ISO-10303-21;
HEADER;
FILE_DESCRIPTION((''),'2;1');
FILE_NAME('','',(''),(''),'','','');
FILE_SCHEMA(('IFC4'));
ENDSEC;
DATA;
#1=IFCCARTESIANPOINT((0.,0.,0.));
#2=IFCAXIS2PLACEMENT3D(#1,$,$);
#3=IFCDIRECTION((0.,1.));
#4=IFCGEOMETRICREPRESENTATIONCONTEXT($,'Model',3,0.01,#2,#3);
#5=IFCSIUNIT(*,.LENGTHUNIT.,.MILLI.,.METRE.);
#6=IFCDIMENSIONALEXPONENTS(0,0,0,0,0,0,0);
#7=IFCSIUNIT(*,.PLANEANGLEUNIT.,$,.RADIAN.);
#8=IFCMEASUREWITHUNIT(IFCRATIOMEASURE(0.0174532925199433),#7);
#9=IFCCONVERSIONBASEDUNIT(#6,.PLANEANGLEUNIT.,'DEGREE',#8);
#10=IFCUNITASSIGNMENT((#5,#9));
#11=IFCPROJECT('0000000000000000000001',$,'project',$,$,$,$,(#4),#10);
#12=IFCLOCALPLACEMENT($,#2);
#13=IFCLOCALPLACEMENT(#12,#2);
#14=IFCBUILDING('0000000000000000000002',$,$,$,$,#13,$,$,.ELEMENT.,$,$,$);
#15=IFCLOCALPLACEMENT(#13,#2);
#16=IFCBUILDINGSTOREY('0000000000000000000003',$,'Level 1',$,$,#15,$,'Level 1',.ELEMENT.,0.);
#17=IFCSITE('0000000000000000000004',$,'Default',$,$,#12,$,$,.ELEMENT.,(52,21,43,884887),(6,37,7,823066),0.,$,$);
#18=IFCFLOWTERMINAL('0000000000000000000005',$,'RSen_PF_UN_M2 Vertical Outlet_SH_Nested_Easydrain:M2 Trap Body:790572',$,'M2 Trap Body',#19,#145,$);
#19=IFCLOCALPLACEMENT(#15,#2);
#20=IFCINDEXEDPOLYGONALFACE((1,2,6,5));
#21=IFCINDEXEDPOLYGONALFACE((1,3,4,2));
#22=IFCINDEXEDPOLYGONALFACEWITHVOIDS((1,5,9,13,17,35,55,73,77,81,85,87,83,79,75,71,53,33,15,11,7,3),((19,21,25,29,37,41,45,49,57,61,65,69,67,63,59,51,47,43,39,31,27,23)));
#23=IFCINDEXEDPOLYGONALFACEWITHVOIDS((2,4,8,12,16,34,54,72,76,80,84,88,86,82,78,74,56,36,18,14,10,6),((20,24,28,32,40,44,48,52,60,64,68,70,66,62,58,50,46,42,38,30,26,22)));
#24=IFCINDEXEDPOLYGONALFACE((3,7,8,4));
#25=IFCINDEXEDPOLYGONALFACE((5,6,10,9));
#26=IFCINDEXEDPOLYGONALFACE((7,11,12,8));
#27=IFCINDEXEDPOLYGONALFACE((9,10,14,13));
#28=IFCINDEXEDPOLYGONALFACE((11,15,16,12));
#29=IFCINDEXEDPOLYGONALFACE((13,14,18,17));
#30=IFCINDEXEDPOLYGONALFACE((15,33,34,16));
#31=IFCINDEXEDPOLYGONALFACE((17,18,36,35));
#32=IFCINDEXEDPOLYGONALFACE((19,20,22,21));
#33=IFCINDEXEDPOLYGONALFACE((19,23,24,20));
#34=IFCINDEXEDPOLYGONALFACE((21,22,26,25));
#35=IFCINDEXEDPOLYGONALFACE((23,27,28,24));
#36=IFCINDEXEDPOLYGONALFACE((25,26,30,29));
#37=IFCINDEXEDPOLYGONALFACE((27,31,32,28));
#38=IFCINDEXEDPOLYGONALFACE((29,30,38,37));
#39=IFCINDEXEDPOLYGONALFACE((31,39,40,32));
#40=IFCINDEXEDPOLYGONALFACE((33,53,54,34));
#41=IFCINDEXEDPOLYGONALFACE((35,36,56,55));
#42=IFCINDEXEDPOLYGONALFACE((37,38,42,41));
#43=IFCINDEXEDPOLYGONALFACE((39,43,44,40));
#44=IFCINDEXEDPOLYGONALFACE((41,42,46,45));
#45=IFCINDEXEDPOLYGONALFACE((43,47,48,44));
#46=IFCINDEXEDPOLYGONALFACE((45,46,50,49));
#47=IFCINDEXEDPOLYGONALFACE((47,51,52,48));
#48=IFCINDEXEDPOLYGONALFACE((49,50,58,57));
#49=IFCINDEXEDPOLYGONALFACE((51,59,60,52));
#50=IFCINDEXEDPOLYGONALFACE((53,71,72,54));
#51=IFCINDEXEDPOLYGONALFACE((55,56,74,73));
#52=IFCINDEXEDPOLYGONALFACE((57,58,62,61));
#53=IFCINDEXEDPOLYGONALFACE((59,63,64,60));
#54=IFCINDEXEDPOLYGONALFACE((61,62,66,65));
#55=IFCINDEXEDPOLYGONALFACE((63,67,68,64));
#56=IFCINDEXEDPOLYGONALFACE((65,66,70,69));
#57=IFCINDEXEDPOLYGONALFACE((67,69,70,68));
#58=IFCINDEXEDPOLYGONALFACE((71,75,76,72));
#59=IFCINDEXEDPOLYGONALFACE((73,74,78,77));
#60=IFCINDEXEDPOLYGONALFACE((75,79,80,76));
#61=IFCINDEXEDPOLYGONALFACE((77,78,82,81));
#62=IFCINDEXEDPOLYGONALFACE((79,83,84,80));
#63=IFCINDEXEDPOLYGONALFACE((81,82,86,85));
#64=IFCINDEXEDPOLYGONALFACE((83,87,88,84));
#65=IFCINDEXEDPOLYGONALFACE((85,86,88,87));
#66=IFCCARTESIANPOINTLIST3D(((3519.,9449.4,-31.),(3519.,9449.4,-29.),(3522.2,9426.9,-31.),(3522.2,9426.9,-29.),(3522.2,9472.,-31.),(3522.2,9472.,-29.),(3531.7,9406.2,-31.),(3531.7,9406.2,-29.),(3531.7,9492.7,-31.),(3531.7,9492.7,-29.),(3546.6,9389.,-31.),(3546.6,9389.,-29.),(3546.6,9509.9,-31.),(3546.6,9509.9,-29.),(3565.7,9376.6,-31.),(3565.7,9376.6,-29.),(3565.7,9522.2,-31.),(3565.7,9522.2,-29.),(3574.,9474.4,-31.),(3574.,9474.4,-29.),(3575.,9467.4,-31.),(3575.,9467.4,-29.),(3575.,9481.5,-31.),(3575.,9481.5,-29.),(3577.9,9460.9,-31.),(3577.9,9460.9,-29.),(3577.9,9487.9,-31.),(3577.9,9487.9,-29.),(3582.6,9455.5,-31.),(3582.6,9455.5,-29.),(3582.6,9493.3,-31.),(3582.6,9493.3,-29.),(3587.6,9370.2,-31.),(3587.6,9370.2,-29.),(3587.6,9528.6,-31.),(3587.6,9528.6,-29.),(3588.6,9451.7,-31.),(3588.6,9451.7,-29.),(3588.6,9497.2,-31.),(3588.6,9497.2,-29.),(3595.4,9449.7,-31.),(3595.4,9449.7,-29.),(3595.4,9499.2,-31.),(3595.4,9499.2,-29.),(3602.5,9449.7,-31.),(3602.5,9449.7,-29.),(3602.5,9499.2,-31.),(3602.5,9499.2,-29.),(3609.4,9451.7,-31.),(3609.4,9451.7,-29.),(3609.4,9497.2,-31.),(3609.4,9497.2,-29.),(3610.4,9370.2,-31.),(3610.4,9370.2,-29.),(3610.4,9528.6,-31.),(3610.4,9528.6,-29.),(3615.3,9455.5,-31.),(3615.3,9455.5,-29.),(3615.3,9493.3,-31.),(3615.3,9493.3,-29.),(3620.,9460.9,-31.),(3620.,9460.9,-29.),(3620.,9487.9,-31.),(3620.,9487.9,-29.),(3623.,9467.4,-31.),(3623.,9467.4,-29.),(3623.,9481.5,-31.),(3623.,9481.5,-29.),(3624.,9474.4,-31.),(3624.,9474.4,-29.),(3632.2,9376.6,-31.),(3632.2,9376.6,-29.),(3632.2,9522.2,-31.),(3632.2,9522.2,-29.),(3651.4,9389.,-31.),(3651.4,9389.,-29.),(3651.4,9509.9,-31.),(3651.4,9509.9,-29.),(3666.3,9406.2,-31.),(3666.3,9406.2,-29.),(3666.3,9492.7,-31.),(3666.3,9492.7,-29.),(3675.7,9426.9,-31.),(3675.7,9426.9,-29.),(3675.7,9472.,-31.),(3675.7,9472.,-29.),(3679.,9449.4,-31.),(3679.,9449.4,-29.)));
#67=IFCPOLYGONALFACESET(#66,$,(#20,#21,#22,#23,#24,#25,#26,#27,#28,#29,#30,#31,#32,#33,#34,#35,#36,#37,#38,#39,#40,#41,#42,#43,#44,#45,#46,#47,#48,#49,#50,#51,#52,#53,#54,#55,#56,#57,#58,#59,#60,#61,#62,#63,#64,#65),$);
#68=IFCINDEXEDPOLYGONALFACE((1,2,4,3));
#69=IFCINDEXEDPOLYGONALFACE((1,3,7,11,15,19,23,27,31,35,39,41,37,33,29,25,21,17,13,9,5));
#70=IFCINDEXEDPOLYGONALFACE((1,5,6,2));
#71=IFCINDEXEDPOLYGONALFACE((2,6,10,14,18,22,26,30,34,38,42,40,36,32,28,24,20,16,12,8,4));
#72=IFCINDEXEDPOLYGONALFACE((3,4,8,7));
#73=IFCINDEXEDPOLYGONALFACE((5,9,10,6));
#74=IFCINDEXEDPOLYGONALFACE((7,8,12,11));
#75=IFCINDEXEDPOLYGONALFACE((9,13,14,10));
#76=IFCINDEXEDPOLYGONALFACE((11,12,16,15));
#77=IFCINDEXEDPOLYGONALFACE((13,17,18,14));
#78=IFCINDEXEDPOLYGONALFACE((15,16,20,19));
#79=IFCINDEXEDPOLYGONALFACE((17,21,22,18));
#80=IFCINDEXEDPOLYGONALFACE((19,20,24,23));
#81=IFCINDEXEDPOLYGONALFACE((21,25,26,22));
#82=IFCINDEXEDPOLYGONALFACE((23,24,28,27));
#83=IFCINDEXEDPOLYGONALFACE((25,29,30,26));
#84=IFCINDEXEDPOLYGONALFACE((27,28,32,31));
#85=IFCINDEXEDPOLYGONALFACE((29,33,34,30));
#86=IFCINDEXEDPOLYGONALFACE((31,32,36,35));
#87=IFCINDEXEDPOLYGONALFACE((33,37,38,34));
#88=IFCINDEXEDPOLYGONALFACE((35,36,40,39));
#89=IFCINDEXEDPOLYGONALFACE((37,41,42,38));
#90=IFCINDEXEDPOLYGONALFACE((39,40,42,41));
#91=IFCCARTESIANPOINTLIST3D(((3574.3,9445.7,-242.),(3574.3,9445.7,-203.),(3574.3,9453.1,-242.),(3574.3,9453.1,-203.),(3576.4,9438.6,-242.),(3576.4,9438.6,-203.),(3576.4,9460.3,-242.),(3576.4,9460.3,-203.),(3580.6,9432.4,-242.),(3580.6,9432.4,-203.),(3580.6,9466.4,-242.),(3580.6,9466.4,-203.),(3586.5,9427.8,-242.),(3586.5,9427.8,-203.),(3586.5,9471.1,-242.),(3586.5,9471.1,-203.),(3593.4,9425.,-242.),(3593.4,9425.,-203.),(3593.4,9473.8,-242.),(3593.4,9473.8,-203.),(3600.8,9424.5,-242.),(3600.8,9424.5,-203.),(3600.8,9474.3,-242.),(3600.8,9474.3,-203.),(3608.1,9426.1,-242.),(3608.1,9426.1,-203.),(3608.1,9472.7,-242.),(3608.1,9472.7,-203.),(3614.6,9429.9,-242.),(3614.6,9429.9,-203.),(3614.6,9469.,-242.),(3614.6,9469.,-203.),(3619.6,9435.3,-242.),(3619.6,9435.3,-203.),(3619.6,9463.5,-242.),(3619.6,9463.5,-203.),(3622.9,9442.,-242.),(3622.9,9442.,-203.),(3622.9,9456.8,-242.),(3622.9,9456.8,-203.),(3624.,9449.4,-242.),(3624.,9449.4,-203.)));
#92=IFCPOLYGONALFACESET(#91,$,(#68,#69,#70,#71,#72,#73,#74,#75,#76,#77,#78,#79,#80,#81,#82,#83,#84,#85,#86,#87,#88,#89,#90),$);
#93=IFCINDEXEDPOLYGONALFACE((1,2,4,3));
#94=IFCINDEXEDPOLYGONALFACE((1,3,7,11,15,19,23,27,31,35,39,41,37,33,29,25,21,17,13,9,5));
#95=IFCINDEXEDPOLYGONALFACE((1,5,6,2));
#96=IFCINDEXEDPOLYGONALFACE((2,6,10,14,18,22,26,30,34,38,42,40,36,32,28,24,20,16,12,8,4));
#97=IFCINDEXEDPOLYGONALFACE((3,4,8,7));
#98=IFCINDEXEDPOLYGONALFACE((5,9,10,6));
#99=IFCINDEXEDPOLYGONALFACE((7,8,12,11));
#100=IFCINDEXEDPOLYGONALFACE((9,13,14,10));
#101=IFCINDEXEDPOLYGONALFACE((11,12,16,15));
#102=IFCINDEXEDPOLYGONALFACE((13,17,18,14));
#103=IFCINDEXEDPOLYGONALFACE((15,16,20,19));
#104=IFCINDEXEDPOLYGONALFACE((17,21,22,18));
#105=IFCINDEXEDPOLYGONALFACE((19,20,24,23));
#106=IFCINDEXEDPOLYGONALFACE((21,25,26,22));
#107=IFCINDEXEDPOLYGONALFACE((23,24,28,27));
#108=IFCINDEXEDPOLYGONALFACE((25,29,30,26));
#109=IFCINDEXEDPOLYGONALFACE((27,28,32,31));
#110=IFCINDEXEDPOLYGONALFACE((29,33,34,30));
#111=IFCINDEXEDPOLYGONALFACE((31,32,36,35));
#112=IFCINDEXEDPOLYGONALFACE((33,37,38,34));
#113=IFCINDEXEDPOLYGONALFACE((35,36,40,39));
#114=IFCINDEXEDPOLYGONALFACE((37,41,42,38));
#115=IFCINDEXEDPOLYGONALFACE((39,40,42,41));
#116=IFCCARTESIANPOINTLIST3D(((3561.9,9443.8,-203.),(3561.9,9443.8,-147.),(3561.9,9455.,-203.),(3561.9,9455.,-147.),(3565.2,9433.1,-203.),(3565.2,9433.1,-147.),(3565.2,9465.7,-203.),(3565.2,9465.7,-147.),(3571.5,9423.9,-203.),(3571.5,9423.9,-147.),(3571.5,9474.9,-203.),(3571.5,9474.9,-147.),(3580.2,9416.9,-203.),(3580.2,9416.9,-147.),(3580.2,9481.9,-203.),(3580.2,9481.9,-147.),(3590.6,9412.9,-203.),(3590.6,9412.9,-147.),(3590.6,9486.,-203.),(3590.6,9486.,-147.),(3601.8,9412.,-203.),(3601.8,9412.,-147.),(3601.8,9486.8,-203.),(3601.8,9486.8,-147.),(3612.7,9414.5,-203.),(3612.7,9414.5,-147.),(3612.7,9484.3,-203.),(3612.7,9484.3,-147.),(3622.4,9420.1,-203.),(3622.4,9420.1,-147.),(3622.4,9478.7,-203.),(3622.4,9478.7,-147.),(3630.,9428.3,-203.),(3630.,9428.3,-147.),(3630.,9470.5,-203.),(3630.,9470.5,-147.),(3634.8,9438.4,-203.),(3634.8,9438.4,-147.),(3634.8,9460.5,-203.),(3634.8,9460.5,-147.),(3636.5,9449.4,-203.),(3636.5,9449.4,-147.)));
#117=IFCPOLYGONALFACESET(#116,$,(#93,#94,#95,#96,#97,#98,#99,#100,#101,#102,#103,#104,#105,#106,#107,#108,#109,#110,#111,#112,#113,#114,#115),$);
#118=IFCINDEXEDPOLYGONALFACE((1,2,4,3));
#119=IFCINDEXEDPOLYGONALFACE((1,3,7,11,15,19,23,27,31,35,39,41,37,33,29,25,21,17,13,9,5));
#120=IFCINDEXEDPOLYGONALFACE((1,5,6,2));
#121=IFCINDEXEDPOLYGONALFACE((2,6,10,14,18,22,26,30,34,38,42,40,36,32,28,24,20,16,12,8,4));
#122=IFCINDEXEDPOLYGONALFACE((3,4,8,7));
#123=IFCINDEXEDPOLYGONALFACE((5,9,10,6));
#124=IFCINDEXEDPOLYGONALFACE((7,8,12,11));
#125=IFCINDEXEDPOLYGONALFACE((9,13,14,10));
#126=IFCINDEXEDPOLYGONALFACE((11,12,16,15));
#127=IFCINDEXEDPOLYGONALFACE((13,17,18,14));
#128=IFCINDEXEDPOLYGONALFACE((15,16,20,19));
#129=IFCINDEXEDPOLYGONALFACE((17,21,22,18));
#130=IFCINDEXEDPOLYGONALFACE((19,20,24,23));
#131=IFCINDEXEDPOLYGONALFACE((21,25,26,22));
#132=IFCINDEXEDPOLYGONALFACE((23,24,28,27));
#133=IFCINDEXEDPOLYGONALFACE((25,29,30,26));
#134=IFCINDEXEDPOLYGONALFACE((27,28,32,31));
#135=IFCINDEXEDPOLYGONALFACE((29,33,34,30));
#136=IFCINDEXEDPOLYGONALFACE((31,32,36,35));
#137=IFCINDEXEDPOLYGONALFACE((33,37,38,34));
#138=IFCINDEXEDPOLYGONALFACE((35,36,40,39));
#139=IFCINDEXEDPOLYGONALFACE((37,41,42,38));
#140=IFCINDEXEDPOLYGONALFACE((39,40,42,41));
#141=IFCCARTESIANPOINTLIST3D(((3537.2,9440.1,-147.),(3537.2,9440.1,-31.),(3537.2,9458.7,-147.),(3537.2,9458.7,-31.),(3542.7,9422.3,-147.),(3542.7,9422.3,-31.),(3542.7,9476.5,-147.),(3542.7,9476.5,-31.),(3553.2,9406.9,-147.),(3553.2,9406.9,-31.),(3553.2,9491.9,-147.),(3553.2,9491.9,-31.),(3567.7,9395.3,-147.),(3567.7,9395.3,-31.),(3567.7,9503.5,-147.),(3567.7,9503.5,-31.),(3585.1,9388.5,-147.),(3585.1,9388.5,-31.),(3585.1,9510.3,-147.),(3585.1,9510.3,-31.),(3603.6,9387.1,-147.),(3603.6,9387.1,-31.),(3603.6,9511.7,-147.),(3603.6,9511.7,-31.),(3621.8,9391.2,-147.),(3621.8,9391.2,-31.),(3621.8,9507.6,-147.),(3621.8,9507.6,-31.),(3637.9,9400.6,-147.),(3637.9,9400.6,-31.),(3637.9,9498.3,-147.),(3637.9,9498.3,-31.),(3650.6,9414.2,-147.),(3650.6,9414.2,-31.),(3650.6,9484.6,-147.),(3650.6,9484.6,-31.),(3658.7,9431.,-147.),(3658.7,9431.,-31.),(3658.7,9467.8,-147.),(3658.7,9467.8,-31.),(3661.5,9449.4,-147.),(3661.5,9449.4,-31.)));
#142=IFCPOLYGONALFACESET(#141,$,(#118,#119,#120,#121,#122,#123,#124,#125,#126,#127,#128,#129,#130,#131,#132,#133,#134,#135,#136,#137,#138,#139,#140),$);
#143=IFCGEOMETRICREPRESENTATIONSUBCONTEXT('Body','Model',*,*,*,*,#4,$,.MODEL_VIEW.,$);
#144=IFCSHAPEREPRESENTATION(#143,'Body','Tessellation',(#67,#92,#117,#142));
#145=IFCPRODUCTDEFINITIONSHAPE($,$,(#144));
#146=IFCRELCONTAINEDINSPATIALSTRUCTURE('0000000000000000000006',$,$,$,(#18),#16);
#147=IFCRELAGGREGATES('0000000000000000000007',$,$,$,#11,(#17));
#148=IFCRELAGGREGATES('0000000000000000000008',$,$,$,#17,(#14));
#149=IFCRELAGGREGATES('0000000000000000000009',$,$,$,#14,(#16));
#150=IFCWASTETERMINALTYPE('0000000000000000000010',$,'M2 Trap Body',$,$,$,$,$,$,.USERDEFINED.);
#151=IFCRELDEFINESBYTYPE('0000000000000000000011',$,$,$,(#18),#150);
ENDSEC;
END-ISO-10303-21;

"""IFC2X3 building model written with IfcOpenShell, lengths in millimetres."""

from ifc_helpers import new_model, entity, si_unit, converted_unit, direction, frame, frame_2d, origin, origin_2d_with_axis, place, context, subcontext, project, spatial, circle_curve, parameter, trimmed, segment, composite_curve, circle, outline, extrude, source, transform, mapped, type_object, type_shapes, element, save


model = new_model("IFC2X3")

# Units and contexts
model_context = context("Model", 3, precision=0.01, world=origin(), true_north=direction((0.0, 1.0)))
body_context = subcontext(model_context, "Body", "Model", "MODEL_VIEW")
ifc_project = project(units=[si_unit("LENGTHUNIT", "METRE", prefix="MILLI"), converted_unit("PLANEANGLEUNIT", "DEGREE", entity("IfcRatioMeasure", 0.0174532925199433), si_unit("PLANEANGLEUNIT", "RADIAN"), dimensions=[0, 0, 0, 0, 0, 0, 0])], contexts=[model_context])

# Site, building, storey
site_placement = place(None, origin())
site = spatial("IfcSite", under=ifc_project, at=site_placement, Name="Default", CompositionType="ELEMENT", RefLatitude=(52, 21, 43, 884887), RefLongitude=(6, 37, 7, 823066), RefElevation=0.0)
building_placement = place(site_placement, origin())
building = spatial("IfcBuilding", under=site, at=building_placement, CompositionType="ELEMENT")
storey_placement = place(building_placement, origin())
storey = spatial("IfcBuildingStorey", under=building, at=storey_placement, Name="Level 1", LongName="Level 1", CompositionType="ELEMENT", Elevation=0.0)

# Flow terminal
waste_terminal_type_1 = type_object("IfcWasteTerminalType", Name="M2 Trap Body", PredefinedType="USERDEFINED")
shared_shape_1 = source(origin(), body_context, "Body", "SweptSolid", [
    extrude(outline(composite_curve([segment(trimmed(circle_curve(origin_2d_with_axis(), 80.0), [parameter(0.0)], [parameter(180.0)], True, "PARAMETER"), True, "CONTINUOUS"), segment(trimmed(circle_curve(origin_2d_with_axis(), 80.0), [parameter(180.0)], [parameter(360.0)], True, "PARAMETER"), True, "CONTINUOUS")], self_intersect=False), holes=[composite_curve([segment(trimmed(circle_curve(frame_2d((0.0, 25.0), x_axis=(1.0, 0.0)), 25.0), [parameter(180.0)], [parameter(360.0)], True, "PARAMETER"), False, "CONTINUOUS"), segment(trimmed(circle_curve(frame_2d((0.0, 25.0), x_axis=(1.0, 0.0)), 25.0), [parameter(0.0)], [parameter(180.0)], True, "PARAMETER"), False, "CONTINUOUS")], self_intersect=False)]), frame((0.0, -25.0, -2.0)), (0.0, 0.0, 1.0), 2.0),
    extrude(circle(Radius=25.0, at=frame_2d((0.0, 0.0), x_axis=(1.0, 0.0))), frame((0.0, -25.0, -213.0)), (0.0, 0.0, 1.0), 39.0),
    extrude(circle(Radius=37.5, at=frame_2d((0.0, 0.0), x_axis=(1.0, 0.0))), frame((0.0, -25.0, -174.0)), (0.0, 0.0, 1.0), 56.0),
    extrude(circle(Radius=62.5, at=frame_2d((0.0, 0.0), x_axis=(1.0, 0.0))), frame((0.0, -25.0, -118.0)), (0.0, 0.0, 1.0), 116.0),
])
type_shapes(waste_terminal_type_1, [shared_shape_1])
for number, where, name in (
    (1, (3599.0, 9474.4, -29.0), "RSen_PF_UN_M2 Vertical Outlet_SH_Nested_Easydrain:M2 Trap Body:790572"),
):
    element("IfcFlowTerminal", number, at=place(storey_placement, frame(where)), inside=storey, type_object=waste_terminal_type_1, Name=name, ObjectType="M2 Trap Body", context=body_context, shape_type="MappedRepresentation", body=[
        mapped(shared_shape_1, transform((0.0, 0.0, 0.0), scale=1.0)),
    ])

save(model, "model.ifc")
